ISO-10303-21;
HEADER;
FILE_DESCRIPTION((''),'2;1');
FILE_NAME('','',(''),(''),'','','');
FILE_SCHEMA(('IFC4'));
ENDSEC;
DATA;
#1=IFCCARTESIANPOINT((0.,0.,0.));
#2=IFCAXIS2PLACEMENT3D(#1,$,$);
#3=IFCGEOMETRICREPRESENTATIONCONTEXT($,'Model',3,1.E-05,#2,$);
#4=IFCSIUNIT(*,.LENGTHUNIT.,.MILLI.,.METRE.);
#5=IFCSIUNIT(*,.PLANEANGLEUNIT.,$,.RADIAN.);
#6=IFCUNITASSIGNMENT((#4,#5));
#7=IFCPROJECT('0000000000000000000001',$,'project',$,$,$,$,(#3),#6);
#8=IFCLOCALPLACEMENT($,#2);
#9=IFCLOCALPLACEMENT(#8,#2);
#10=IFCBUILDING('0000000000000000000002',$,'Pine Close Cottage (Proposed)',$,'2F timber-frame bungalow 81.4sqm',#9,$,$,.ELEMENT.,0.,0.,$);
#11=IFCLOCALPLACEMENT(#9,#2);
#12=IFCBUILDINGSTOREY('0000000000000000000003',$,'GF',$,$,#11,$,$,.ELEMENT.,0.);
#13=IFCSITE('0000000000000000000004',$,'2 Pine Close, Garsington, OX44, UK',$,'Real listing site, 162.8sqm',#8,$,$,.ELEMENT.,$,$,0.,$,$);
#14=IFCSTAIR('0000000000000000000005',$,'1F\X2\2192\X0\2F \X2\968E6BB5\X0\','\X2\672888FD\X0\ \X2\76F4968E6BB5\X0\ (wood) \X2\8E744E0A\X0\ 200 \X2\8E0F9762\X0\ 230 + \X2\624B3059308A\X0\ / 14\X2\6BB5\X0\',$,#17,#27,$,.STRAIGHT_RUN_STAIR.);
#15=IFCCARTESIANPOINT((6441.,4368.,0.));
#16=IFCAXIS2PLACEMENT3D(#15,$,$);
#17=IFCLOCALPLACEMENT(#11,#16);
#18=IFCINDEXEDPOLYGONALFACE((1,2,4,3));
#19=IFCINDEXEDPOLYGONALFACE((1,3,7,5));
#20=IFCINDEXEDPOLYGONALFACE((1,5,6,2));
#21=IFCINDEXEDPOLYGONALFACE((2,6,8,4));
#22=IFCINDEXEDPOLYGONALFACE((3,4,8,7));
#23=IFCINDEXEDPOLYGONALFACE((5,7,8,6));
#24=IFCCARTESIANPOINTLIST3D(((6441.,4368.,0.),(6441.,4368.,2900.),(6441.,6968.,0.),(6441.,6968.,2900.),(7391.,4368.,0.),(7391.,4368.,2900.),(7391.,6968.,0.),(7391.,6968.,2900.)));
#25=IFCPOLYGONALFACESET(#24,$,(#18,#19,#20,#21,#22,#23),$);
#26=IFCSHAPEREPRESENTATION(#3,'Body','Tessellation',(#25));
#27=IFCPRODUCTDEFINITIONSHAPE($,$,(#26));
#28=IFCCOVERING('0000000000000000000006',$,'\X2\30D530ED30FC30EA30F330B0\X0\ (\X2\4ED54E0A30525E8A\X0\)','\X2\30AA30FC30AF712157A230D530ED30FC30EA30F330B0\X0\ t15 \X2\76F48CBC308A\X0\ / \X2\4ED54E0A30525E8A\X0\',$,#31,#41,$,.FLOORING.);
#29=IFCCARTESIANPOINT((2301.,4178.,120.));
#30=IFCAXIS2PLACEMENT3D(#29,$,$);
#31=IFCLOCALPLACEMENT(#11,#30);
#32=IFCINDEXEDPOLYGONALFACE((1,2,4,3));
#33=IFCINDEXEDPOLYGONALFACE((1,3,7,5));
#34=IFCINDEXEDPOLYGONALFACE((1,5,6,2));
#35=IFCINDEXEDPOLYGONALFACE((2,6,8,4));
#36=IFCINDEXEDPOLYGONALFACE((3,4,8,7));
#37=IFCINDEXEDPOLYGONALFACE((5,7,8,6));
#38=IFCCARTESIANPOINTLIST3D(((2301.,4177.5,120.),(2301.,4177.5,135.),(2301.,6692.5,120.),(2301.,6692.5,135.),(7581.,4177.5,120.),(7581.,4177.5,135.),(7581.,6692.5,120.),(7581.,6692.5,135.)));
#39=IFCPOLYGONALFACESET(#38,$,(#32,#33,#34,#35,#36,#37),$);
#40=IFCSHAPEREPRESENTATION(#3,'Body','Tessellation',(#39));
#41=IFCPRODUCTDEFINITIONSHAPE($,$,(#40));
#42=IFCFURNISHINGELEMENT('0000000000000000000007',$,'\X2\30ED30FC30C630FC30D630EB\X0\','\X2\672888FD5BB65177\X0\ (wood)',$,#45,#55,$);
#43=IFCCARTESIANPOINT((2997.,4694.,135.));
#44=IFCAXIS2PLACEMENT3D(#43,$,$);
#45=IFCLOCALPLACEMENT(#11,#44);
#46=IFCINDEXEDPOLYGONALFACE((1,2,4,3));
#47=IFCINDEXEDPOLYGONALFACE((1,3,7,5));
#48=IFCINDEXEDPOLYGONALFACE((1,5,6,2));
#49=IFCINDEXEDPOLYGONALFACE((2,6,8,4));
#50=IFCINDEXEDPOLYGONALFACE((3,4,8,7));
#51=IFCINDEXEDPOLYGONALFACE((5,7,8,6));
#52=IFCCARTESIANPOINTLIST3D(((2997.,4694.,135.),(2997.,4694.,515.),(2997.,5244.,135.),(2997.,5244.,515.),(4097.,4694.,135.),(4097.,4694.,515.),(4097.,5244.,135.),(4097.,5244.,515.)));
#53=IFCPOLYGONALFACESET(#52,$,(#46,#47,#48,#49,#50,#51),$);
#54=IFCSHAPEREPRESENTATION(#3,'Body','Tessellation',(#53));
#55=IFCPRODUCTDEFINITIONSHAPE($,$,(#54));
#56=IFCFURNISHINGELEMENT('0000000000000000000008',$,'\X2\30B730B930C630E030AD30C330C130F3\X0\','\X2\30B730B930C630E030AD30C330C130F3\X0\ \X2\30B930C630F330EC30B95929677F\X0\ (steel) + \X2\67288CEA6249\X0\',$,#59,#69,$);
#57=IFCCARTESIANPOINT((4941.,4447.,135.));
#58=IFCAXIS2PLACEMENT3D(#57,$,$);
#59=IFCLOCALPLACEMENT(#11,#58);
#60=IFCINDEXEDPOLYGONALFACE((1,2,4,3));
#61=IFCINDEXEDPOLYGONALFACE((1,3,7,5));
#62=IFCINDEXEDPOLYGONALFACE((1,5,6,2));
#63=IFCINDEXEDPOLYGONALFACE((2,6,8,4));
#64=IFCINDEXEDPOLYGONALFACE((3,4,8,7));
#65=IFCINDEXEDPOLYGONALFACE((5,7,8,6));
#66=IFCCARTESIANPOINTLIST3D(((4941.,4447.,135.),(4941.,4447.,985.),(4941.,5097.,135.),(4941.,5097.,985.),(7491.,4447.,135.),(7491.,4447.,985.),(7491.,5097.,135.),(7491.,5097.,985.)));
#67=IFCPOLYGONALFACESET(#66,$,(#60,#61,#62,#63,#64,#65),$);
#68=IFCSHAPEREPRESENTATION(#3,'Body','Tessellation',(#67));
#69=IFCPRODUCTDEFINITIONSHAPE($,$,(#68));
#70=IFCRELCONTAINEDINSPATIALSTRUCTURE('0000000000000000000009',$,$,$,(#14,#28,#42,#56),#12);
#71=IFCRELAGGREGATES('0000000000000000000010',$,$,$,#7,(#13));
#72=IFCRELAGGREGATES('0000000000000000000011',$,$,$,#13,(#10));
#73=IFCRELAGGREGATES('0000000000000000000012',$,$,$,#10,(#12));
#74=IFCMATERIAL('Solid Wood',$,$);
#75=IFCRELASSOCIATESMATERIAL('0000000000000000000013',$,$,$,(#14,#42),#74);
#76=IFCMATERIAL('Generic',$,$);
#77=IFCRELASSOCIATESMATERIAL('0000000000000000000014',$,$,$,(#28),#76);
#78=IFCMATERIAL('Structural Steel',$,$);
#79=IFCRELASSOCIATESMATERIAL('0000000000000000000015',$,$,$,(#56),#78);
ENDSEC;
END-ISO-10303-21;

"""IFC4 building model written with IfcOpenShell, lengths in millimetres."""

from ifc_helpers import new_model, si_unit, frame, frame_2d, origin, place, context, project, spatial, rectangle, extrude, material, element, save


model = new_model("IFC4")

# Units and contexts
model_context = context("Model", 3, precision=1e-05, world=origin())
ifc_project = project(units=[si_unit("LENGTHUNIT", "METRE", prefix="MILLI"), si_unit("PLANEANGLEUNIT", "RADIAN")], contexts=[model_context])

# Site, building, storey
site_placement = place(None, origin())
site = spatial("IfcSite", under=ifc_project, at=site_placement, Name="2 Pine Close, Garsington, OX44, UK", ObjectType="Real listing site, 162.8sqm", CompositionType="ELEMENT", RefElevation=0.0)
building_placement = place(site_placement, origin())
building = spatial("IfcBuilding", under=site, at=building_placement, Name="Pine Close Cottage (Proposed)", ObjectType="2F timber-frame bungalow 81.4sqm", CompositionType="ELEMENT", ElevationOfRefHeight=0.0, ElevationOfTerrain=0.0)
storey_placement = place(building_placement, origin())
storey = spatial("IfcBuildingStorey", under=building, at=storey_placement, Name="GF", CompositionType="ELEMENT", Elevation=0.0)

# Shared definitions
ifc_material_1 = material(Name="Solid Wood")

# Stair
stair_placement = place(storey_placement, frame((6441.0, 4368.0, 0.0)))
element("IfcStair", 1, at=stair_placement, inside=storey, material=ifc_material_1, Name="1F→2F 階段", Description="木製 直階段 (wood) 蹴上 200 踏面 230 + 手すり / 14段", PredefinedType="STRAIGHT_RUN_STAIR", context=model_context, shape_type="SweptSolid", body=[
    extrude(rectangle(XDim=950.0, YDim=2600.0, at=frame_2d((475.0, 1300.0))), frame((6441.0, 4368.0, 0.0)), (0.0, 0.0, 1.0), 2900.0),
])

# Covering
ifc_material_2 = material(Name="Generic")
covering_placement = place(storey_placement, frame((2301.0, 4178.0, 120.0)))
element("IfcCovering", 2, at=covering_placement, inside=storey, material=ifc_material_2, Name="フローリング (仕上げ床)", Description="オーク無垢フローリング t15 直貼り / 仕上げ床", PredefinedType="FLOORING", context=model_context, shape_type="SweptSolid", body=[
    extrude(rectangle(XDim=5280.0, YDim=2515.0, at=frame_2d((2640.0, 1257.0))), frame((2301.0, 4178.0, 120.0)), (0.0, 0.0, 1.0), 15.0),
])

# Furnishing elements
furnishing_1_placement = place(storey_placement, frame((2997.0, 4694.0, 135.0)))
element("IfcFurnishingElement", 3, at=furnishing_1_placement, inside=storey, material=ifc_material_1, Name="ローテーブル", Description="木製家具 (wood)", context=model_context, shape_type="SweptSolid", body=[
    extrude(rectangle(XDim=1100.0, YDim=550.0, at=frame_2d((550.0, 275.0))), frame((2997.0, 4694.0, 135.0)), (0.0, 0.0, 1.0), 380.0),
])
ifc_material_3 = material(Name="Structural Steel")
furnishing_2_placement = place(storey_placement, frame((4941.0, 4447.0, 135.0)))
element("IfcFurnishingElement", 4, at=furnishing_2_placement, inside=storey, material=ifc_material_3, Name="システムキッチン", Description="システムキッチン ステンレス天板 (steel) + 木質扉", context=model_context, shape_type="SweptSolid", body=[
    extrude(rectangle(XDim=2550.0, YDim=650.0, at=frame_2d((1275.0, 325.0))), frame((4941.0, 4447.0, 135.0)), (0.0, 0.0, 1.0), 850.0),
])

save(model, "model.ifc")
